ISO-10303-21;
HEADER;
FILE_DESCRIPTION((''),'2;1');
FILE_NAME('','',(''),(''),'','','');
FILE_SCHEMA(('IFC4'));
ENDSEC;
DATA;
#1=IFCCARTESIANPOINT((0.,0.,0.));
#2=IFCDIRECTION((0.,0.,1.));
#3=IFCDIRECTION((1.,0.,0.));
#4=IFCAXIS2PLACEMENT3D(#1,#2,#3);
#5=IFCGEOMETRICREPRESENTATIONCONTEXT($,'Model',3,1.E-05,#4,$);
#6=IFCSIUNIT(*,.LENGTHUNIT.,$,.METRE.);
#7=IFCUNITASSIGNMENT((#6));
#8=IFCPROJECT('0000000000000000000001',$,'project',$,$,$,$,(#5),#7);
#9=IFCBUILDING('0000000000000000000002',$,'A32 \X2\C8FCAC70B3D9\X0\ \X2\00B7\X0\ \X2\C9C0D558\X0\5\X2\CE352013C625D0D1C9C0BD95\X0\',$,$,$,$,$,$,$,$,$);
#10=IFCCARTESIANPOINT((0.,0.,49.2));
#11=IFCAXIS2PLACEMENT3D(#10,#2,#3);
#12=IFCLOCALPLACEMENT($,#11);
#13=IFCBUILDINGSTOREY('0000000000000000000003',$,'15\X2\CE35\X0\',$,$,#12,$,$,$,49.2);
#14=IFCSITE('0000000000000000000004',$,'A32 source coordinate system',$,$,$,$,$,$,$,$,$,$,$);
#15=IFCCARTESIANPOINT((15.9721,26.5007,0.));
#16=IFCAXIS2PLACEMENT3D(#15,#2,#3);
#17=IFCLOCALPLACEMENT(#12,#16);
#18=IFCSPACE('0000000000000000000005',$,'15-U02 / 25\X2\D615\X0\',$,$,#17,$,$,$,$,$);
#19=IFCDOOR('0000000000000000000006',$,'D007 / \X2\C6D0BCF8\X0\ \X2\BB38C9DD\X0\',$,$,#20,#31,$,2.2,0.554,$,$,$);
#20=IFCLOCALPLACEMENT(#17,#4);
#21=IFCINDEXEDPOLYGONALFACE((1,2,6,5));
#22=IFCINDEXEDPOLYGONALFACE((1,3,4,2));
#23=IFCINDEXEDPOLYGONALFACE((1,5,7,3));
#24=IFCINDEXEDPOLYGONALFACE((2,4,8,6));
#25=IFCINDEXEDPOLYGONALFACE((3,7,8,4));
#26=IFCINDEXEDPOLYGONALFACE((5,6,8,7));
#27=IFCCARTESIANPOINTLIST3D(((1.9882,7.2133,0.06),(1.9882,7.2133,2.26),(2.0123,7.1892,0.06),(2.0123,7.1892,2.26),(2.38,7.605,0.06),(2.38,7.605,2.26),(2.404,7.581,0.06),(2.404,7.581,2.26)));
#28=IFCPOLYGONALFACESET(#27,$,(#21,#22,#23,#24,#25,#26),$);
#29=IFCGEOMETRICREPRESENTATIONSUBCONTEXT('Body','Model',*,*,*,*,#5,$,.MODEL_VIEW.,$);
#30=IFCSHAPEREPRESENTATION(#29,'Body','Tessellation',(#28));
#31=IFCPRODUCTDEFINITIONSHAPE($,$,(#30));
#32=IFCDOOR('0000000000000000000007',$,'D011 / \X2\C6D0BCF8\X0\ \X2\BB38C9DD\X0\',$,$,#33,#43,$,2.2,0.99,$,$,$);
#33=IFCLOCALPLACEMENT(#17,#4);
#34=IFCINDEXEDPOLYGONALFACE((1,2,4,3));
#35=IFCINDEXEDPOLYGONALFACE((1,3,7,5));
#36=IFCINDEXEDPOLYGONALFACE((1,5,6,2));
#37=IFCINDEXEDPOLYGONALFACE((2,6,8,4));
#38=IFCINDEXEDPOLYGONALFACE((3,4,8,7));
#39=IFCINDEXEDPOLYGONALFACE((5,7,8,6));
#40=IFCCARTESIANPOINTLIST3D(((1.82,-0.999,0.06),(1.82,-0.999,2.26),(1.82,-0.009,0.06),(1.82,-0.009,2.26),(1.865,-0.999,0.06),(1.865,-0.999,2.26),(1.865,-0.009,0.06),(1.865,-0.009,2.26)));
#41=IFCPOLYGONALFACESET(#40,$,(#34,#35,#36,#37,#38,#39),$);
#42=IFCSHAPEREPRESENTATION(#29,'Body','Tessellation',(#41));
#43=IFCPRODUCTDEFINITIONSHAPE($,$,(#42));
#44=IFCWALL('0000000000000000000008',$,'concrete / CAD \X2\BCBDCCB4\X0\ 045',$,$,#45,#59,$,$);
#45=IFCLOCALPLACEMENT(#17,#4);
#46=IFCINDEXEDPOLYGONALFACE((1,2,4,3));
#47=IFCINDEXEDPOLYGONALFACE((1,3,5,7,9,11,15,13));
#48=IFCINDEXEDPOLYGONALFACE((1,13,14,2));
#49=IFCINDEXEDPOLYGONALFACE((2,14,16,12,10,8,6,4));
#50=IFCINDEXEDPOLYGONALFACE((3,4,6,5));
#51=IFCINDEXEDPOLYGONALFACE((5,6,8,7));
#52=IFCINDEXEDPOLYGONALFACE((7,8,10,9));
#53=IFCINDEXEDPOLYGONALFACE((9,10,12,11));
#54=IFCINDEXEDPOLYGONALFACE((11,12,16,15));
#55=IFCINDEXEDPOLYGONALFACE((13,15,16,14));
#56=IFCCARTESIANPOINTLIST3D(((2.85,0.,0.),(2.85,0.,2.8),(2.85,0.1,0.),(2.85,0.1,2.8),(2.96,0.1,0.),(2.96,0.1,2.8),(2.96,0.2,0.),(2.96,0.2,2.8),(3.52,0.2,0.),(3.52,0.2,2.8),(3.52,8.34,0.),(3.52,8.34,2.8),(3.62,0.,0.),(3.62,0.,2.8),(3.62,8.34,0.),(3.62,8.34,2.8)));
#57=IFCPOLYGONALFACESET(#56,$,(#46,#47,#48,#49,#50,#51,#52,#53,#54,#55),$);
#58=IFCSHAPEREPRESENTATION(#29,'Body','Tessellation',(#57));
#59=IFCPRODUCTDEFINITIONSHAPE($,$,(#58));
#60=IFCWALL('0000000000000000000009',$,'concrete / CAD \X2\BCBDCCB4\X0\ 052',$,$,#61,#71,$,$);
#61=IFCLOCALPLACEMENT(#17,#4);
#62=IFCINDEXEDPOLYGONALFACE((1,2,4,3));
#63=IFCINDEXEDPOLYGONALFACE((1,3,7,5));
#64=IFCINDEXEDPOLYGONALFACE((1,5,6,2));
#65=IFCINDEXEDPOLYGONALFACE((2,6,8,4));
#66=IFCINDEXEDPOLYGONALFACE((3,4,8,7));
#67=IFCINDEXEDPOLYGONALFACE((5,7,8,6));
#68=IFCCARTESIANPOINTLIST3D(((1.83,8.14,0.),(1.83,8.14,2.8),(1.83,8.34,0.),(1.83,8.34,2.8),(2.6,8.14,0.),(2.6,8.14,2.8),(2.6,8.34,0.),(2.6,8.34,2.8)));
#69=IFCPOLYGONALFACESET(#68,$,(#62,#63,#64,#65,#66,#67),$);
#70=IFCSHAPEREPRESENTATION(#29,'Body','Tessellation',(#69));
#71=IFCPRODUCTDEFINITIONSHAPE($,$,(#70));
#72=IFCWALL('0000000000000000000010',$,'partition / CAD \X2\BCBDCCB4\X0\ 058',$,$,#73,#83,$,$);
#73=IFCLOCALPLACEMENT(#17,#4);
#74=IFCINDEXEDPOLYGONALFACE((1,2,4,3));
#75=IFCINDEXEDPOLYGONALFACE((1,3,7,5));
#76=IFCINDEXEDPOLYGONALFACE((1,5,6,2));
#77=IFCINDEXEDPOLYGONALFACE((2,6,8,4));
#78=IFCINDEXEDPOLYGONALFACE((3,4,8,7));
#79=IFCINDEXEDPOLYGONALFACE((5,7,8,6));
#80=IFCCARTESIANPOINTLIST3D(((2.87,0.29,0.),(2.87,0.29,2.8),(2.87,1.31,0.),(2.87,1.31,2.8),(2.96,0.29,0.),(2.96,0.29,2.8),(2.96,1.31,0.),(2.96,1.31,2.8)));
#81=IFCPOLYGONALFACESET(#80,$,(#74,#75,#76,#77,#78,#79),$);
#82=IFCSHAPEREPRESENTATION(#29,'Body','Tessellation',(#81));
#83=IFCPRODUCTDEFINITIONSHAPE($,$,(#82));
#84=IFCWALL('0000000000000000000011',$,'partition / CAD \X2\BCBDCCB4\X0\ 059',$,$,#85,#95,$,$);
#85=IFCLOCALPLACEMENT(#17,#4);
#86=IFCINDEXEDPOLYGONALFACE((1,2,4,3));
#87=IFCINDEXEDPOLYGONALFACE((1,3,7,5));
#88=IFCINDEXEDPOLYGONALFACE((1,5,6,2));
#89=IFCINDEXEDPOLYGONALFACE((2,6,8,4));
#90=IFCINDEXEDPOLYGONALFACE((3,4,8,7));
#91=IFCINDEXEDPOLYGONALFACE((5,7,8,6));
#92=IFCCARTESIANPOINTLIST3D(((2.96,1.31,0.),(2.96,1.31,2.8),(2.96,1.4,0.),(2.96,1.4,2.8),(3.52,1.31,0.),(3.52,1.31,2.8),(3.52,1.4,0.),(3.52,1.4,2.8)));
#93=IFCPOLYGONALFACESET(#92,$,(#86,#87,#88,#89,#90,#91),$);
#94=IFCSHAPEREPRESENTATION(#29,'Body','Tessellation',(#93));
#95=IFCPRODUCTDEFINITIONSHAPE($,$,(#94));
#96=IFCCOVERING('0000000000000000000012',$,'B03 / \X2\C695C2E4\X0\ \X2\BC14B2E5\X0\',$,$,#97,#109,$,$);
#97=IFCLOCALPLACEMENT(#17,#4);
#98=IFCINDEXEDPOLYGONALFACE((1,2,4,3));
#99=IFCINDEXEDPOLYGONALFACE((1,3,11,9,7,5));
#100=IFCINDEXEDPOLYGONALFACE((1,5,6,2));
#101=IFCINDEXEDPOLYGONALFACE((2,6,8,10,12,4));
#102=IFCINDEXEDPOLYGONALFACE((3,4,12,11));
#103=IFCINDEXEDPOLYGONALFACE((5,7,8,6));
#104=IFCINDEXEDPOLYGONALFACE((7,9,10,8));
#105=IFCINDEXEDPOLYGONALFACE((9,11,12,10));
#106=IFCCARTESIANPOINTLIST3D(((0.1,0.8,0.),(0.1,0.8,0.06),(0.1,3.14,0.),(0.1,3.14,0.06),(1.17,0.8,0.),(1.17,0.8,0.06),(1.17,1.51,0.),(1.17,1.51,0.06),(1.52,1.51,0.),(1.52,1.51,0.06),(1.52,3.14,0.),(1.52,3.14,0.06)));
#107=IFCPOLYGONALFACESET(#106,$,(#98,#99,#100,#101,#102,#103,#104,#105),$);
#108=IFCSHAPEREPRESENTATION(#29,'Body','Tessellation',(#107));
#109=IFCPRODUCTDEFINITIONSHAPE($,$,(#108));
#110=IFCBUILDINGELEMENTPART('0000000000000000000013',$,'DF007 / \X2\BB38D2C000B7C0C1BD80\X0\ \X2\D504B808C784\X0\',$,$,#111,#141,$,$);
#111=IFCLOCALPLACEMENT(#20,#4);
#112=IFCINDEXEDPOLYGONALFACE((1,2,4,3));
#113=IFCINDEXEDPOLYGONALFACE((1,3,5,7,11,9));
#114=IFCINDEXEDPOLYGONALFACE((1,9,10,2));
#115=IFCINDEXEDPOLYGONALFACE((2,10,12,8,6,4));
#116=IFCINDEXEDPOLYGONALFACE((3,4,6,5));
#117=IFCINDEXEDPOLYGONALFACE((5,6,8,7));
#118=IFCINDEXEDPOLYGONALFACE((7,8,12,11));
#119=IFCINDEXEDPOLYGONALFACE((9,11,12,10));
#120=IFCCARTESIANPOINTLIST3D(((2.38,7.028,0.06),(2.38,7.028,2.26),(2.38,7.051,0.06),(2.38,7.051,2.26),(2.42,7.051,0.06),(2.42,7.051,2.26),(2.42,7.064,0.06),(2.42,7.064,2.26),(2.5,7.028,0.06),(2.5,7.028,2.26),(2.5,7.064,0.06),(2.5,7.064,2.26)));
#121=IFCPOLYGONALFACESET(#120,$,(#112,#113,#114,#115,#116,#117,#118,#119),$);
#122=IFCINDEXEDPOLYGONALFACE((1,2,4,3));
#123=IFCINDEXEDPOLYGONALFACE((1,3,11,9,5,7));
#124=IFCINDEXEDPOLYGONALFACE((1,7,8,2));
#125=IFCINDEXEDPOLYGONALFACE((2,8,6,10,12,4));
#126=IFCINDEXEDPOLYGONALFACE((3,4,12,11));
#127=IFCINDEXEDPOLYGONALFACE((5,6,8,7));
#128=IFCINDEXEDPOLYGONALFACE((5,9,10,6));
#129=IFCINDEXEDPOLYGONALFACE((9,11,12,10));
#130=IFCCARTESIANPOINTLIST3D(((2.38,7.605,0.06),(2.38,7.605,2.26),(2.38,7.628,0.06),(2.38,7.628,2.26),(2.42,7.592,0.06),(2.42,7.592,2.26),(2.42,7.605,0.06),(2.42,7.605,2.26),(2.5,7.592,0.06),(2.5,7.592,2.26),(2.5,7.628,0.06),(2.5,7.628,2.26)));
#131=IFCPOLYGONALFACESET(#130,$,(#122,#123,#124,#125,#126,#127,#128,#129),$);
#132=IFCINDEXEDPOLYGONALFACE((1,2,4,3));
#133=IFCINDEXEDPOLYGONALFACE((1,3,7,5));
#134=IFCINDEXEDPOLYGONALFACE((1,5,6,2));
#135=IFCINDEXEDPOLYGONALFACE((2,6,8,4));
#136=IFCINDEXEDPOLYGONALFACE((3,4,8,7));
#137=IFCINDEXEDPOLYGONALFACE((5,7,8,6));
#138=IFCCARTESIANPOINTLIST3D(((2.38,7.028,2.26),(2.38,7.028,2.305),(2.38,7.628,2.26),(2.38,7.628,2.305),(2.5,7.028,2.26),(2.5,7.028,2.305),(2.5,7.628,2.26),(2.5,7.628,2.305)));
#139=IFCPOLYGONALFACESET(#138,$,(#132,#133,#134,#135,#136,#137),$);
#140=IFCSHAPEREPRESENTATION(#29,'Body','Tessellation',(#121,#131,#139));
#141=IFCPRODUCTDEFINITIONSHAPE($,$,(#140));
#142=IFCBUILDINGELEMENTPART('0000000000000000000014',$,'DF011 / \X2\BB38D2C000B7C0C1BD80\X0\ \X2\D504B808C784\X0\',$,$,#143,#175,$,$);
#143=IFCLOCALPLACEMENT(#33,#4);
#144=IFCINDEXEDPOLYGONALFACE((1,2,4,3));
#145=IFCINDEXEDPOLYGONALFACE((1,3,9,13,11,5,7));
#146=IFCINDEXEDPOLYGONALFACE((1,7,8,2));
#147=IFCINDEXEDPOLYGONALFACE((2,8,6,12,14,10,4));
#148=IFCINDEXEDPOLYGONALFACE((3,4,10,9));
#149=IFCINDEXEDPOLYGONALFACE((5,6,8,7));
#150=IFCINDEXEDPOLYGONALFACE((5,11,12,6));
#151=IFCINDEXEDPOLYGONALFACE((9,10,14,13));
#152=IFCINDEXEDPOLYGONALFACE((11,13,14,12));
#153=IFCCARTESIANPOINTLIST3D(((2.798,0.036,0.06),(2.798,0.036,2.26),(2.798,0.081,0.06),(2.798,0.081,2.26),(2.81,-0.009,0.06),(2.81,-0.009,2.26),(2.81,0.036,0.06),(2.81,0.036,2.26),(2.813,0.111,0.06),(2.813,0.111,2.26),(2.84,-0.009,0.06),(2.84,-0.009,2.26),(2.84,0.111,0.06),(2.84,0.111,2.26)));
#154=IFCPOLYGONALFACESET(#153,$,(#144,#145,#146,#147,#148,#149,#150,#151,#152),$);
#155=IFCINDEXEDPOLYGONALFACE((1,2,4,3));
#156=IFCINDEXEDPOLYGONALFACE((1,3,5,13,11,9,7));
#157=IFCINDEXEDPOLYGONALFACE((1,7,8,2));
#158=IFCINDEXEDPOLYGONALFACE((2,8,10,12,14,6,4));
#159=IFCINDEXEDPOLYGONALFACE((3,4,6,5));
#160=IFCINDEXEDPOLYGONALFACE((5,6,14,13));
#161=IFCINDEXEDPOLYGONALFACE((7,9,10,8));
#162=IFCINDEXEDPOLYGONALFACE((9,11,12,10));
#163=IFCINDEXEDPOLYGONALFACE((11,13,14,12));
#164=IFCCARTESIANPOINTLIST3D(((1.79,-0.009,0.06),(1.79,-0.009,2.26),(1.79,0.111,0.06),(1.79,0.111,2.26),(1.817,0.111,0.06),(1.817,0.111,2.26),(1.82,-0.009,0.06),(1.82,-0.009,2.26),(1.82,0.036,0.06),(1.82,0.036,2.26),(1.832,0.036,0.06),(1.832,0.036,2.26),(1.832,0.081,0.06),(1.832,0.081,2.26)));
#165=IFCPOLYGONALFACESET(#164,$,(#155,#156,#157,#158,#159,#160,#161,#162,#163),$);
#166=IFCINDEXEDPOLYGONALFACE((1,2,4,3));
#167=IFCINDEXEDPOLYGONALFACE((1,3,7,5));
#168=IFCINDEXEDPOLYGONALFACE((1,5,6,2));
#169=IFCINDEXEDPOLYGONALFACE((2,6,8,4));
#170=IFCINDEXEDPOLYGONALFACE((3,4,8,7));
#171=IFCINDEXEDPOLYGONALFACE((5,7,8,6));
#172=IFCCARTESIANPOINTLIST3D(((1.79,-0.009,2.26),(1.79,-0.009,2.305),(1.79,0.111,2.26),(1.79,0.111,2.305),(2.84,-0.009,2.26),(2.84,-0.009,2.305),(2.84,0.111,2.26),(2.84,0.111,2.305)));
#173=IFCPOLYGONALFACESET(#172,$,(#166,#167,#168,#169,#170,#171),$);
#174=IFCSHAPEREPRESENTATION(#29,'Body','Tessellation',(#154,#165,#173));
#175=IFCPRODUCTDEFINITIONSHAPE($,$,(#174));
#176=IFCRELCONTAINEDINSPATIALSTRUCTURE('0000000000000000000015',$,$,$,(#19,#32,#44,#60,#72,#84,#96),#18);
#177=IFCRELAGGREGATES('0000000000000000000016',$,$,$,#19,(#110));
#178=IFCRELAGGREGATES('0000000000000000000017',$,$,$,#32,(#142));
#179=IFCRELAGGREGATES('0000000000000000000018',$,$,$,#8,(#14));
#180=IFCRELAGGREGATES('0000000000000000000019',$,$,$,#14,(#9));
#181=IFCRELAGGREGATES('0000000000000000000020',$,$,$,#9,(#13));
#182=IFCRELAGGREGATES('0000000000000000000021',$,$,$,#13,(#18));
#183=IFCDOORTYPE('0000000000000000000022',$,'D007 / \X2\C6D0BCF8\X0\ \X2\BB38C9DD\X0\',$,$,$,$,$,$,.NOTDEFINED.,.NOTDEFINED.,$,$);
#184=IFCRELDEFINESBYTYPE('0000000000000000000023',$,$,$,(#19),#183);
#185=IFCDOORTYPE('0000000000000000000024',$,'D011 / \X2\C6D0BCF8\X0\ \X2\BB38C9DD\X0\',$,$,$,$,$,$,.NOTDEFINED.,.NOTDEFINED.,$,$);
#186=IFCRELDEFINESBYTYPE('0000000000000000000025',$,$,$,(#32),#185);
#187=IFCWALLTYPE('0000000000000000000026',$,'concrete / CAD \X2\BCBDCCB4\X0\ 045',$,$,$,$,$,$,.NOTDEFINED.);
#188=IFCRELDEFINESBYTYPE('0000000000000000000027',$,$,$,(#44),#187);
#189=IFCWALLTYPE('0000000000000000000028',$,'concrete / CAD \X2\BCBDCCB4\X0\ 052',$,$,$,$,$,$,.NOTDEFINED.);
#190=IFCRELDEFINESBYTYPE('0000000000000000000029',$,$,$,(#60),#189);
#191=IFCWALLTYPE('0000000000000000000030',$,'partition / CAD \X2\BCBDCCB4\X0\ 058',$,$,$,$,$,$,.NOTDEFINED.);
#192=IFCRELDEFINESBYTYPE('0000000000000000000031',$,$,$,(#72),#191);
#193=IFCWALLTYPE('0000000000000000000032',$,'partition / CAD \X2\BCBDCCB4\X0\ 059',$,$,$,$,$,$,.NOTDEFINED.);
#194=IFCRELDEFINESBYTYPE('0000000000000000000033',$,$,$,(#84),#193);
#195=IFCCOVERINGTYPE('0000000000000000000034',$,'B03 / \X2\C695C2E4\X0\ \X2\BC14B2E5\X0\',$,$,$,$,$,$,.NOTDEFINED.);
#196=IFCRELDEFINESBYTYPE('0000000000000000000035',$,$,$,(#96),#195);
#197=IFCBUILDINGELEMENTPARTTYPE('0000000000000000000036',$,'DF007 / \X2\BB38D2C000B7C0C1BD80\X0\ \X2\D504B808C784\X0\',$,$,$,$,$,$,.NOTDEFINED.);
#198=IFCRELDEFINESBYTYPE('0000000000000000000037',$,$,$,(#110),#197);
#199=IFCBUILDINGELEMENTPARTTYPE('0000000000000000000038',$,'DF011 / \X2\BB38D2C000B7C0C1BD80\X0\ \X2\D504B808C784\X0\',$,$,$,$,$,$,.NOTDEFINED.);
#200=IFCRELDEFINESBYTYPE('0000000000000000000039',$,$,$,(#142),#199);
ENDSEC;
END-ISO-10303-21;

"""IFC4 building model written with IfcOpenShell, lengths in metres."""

from ifc_helpers import new_model, si_unit, frame, origin, origin_with_axes, place, context, subcontext, project, spatial, polyline, outline, extrude, source, transform, mapped, type_object, type_shapes, element, aggregate, save


model = new_model("IFC4")

# Units and contexts
model_context = context("Model", 3, precision=1e-05, world=origin_with_axes())
body_context = subcontext(model_context, "Body", "Model", "MODEL_VIEW")
ifc_project = project(units=[si_unit("LENGTHUNIT", "METRE")], contexts=[model_context])

# Site, building, storey, space
storey_placement = place(None, frame((0.0, 0.0, 49.2), z_axis=(0.0, 0.0, 1.0), x_axis=(1.0, 0.0, 0.0)))
space_placement = place(storey_placement, frame((15.9721, 26.5007, 0.0), z_axis=(0.0, 0.0, 1.0), x_axis=(1.0, 0.0, 0.0)))
site = spatial("IfcSite", under=ifc_project, Name="A32 source coordinate system")
building = spatial("IfcBuilding", under=site, Name="A32 주거동 · 지하5층–옥탑지붕")
storey = spatial("IfcBuildingStorey", under=building, at=storey_placement, Name="15층", Elevation=49.2)
space = spatial("IfcSpace", under=storey, at=space_placement, Name="15-U02 / 25형")

# Doors
door_type_1 = type_object("IfcDoorType", Name="D007 / 원본 문짝", OperationType="NOTDEFINED", PredefinedType="NOTDEFINED")
shared_shape_1 = source(origin(), body_context, "Body", "SweptSolid", [
    extrude(outline(polyline([(2.0123, 7.1892), (1.9882, 7.2133), (2.38, 7.605), (2.404, 7.581), (2.0123, 7.1892)])), frame((0.0, 0.0, 0.06)), (0.0, 0.0, 1.0), 2.2),
])
type_shapes(door_type_1, [shared_shape_1])
door_1_placement = place(space_placement, origin_with_axes())
door_1 = element("IfcDoor", 1, at=door_1_placement, inside=space, type_object=door_type_1, Name="D007 / 원본 문짝", OverallHeight=2.2, OverallWidth=0.554, context=body_context, shape_type="MappedRepresentation", body=[
    mapped(shared_shape_1, transform((0.0, 0.0, 0.0), scale=1.0)),
])
door_type_2 = type_object("IfcDoorType", Name="D011 / 원본 문짝", OperationType="NOTDEFINED", PredefinedType="NOTDEFINED")
shared_shape_2 = source(origin(), body_context, "Body", "SweptSolid", [
    extrude(outline(polyline([(1.865, -0.999), (1.82, -0.999), (1.82, -0.009), (1.865, -0.009), (1.865, -0.999)])), frame((0.0, 0.0, 0.06)), (0.0, 0.0, 1.0), 2.2),
])
type_shapes(door_type_2, [shared_shape_2])
door_2_placement = place(space_placement, origin_with_axes())
door_2 = element("IfcDoor", 2, at=door_2_placement, inside=space, type_object=door_type_2, Name="D011 / 원본 문짝", OverallHeight=2.2, OverallWidth=0.99, context=body_context, shape_type="MappedRepresentation", body=[
    mapped(shared_shape_2, transform((0.0, 0.0, 0.0), scale=1.0)),
])

# Walls
wall_type_1 = type_object("IfcWallType", Name="concrete / CAD 벽체 045", PredefinedType="NOTDEFINED")
shared_shape_3 = source(origin(), body_context, "Body", "SweptSolid", [
    extrude(outline(polyline([(2.96, 0.1), (2.96, 0.2), (3.52, 0.2), (3.52, 8.34), (3.72, 8.34), (3.72, 8.34), (3.62, 8.34), (3.62, 0.0), (2.85, 0.0), (2.85, 0.1), (2.96, 0.1)])), origin(), (0.0, 0.0, 1.0), 2.8),
])
type_shapes(wall_type_1, [shared_shape_3])
wall_1_placement = place(space_placement, origin_with_axes())
element("IfcWall", 3, at=wall_1_placement, inside=space, type_object=wall_type_1, Name="concrete / CAD 벽체 045", context=body_context, shape_type="MappedRepresentation", body=[
    mapped(shared_shape_3, transform((0.0, 0.0, 0.0), scale=1.0)),
])
wall_type_2 = type_object("IfcWallType", Name="concrete / CAD 벽체 052", PredefinedType="NOTDEFINED")
shared_shape_4 = source(origin(), body_context, "Body", "SweptSolid", [
    extrude(outline(polyline([(2.6, 8.14), (1.83, 8.14), (1.83, 8.34), (2.6, 8.34), (2.6, 8.14)])), origin(), (0.0, 0.0, 1.0), 2.8),
])
type_shapes(wall_type_2, [shared_shape_4])
wall_2_placement = place(space_placement, origin_with_axes())
element("IfcWall", 4, at=wall_2_placement, inside=space, type_object=wall_type_2, Name="concrete / CAD 벽체 052", context=body_context, shape_type="MappedRepresentation", body=[
    mapped(shared_shape_4, transform((0.0, 0.0, 0.0), scale=1.0)),
])
wall_type_3 = type_object("IfcWallType", Name="partition / CAD 벽체 058", PredefinedType="NOTDEFINED")
shared_shape_5 = source(origin(), body_context, "Body", "SweptSolid", [
    extrude(outline(polyline([(2.96, 1.31), (2.96, 0.29), (2.87, 0.29), (2.87, 1.31), (2.96, 1.31)])), origin(), (0.0, 0.0, 1.0), 2.8),
])
type_shapes(wall_type_3, [shared_shape_5])
wall_3_placement = place(space_placement, origin_with_axes())
element("IfcWall", 5, at=wall_3_placement, inside=space, type_object=wall_type_3, Name="partition / CAD 벽체 058", context=body_context, shape_type="MappedRepresentation", body=[
    mapped(shared_shape_5, transform((0.0, 0.0, 0.0), scale=1.0)),
])
wall_type_4 = type_object("IfcWallType", Name="partition / CAD 벽체 059", PredefinedType="NOTDEFINED")
shared_shape_6 = source(origin(), body_context, "Body", "SweptSolid", [
    extrude(outline(polyline([(3.52, 1.31), (2.96, 1.31), (2.96, 1.4), (3.52, 1.4), (3.52, 1.31)])), origin(), (0.0, 0.0, 1.0), 2.8),
])
type_shapes(wall_type_4, [shared_shape_6])
wall_4_placement = place(space_placement, origin_with_axes())
element("IfcWall", 6, at=wall_4_placement, inside=space, type_object=wall_type_4, Name="partition / CAD 벽체 059", context=body_context, shape_type="MappedRepresentation", body=[
    mapped(shared_shape_6, transform((0.0, 0.0, 0.0), scale=1.0)),
])

# Covering
covering_type_1 = type_object("IfcCoveringType", Name="B03 / 욕실 바닥", PredefinedType="NOTDEFINED")
shared_shape_7 = source(origin(), body_context, "Body", "SweptSolid", [
    extrude(outline(polyline([(1.17, 1.51), (1.17, 0.8), (0.1, 0.8), (0.1, 3.14), (1.52, 3.14), (1.52, 1.51), (1.17, 1.51)])), origin(), (0.0, 0.0, 1.0), 0.06),
])
type_shapes(covering_type_1, [shared_shape_7])
covering_1_placement = place(space_placement, origin_with_axes())
element("IfcCovering", 7, at=covering_1_placement, inside=space, type_object=covering_type_1, Name="B03 / 욕실 바닥", context=body_context, shape_type="MappedRepresentation", body=[
    mapped(shared_shape_7, transform((0.0, 0.0, 0.0), scale=1.0)),
])

# Building element parts
building_element_part_type_1 = type_object("IfcBuildingElementPartType", Name="DF007 / 문틀·상부 프레임", PredefinedType="NOTDEFINED")
shared_shape_8 = source(origin(), body_context, "Body", "SweptSolid", [
    extrude(outline(polyline([(2.38, 7.028), (2.38, 7.051), (2.42, 7.051), (2.42, 7.064), (2.5, 7.064), (2.5, 7.028), (2.38, 7.028)])), frame((0.0, 0.0, 0.06)), (0.0, 0.0, 1.0), 2.2),
    extrude(outline(polyline([(2.5, 7.592), (2.42, 7.592), (2.42, 7.605), (2.38, 7.605), (2.38, 7.628), (2.5, 7.628), (2.5, 7.592)])), frame((0.0, 0.0, 0.06)), (0.0, 0.0, 1.0), 2.2),
    extrude(outline(polyline([(2.38, 7.028), (2.38, 7.628), (2.5, 7.628), (2.5, 7.028), (2.38, 7.028)])), frame((0.0, 0.0, 2.26)), (0.0, 0.0, 1.0), 0.045),
])
type_shapes(building_element_part_type_1, [shared_shape_8])
building_element_part_1_placement = place(door_1_placement, origin_with_axes())
building_element_part_1 = element("IfcBuildingElementPart", 8, at=building_element_part_1_placement, type_object=building_element_part_type_1, Name="DF007 / 문틀·상부 프레임", context=body_context, shape_type="MappedRepresentation", body=[
    mapped(shared_shape_8, transform((0.0, 0.0, 0.0), scale=1.0)),
])
aggregate(door_1, [building_element_part_1])
building_element_part_type_2 = type_object("IfcBuildingElementPartType", Name="DF011 / 문틀·상부 프레임", PredefinedType="NOTDEFINED")
shared_shape_9 = source(origin(), body_context, "Body", "SweptSolid", [
    extrude(outline(polyline([(2.81, -0.009), (2.81, 0.036), (2.798, 0.036), (2.798, 0.081), (2.813, 0.111), (2.84, 0.111), (2.84, -0.009), (2.81, -0.009)])), frame((0.0, 0.0, 0.06)), (0.0, 0.0, 1.0), 2.2),
    extrude(outline(polyline([(1.79, 0.111), (1.817, 0.111), (1.832, 0.081), (1.832, 0.036), (1.82, 0.036), (1.82, -0.009), (1.79, -0.009), (1.79, 0.111)])), frame((0.0, 0.0, 0.06)), (0.0, 0.0, 1.0), 2.2),
    extrude(outline(polyline([(1.79, -0.009), (1.79, 0.111), (2.84, 0.111), (2.84, -0.009), (1.79, -0.009)])), frame((0.0, 0.0, 2.26)), (0.0, 0.0, 1.0), 0.045),
])
type_shapes(building_element_part_type_2, [shared_shape_9])
building_element_part_2_placement = place(door_2_placement, origin_with_axes())
building_element_part_2 = element("IfcBuildingElementPart", 9, at=building_element_part_2_placement, type_object=building_element_part_type_2, Name="DF011 / 문틀·상부 프레임", context=body_context, shape_type="MappedRepresentation", body=[
    mapped(shared_shape_9, transform((0.0, 0.0, 0.0), scale=1.0)),
])
aggregate(door_2, [building_element_part_2])

save(model, "model.ifc")
